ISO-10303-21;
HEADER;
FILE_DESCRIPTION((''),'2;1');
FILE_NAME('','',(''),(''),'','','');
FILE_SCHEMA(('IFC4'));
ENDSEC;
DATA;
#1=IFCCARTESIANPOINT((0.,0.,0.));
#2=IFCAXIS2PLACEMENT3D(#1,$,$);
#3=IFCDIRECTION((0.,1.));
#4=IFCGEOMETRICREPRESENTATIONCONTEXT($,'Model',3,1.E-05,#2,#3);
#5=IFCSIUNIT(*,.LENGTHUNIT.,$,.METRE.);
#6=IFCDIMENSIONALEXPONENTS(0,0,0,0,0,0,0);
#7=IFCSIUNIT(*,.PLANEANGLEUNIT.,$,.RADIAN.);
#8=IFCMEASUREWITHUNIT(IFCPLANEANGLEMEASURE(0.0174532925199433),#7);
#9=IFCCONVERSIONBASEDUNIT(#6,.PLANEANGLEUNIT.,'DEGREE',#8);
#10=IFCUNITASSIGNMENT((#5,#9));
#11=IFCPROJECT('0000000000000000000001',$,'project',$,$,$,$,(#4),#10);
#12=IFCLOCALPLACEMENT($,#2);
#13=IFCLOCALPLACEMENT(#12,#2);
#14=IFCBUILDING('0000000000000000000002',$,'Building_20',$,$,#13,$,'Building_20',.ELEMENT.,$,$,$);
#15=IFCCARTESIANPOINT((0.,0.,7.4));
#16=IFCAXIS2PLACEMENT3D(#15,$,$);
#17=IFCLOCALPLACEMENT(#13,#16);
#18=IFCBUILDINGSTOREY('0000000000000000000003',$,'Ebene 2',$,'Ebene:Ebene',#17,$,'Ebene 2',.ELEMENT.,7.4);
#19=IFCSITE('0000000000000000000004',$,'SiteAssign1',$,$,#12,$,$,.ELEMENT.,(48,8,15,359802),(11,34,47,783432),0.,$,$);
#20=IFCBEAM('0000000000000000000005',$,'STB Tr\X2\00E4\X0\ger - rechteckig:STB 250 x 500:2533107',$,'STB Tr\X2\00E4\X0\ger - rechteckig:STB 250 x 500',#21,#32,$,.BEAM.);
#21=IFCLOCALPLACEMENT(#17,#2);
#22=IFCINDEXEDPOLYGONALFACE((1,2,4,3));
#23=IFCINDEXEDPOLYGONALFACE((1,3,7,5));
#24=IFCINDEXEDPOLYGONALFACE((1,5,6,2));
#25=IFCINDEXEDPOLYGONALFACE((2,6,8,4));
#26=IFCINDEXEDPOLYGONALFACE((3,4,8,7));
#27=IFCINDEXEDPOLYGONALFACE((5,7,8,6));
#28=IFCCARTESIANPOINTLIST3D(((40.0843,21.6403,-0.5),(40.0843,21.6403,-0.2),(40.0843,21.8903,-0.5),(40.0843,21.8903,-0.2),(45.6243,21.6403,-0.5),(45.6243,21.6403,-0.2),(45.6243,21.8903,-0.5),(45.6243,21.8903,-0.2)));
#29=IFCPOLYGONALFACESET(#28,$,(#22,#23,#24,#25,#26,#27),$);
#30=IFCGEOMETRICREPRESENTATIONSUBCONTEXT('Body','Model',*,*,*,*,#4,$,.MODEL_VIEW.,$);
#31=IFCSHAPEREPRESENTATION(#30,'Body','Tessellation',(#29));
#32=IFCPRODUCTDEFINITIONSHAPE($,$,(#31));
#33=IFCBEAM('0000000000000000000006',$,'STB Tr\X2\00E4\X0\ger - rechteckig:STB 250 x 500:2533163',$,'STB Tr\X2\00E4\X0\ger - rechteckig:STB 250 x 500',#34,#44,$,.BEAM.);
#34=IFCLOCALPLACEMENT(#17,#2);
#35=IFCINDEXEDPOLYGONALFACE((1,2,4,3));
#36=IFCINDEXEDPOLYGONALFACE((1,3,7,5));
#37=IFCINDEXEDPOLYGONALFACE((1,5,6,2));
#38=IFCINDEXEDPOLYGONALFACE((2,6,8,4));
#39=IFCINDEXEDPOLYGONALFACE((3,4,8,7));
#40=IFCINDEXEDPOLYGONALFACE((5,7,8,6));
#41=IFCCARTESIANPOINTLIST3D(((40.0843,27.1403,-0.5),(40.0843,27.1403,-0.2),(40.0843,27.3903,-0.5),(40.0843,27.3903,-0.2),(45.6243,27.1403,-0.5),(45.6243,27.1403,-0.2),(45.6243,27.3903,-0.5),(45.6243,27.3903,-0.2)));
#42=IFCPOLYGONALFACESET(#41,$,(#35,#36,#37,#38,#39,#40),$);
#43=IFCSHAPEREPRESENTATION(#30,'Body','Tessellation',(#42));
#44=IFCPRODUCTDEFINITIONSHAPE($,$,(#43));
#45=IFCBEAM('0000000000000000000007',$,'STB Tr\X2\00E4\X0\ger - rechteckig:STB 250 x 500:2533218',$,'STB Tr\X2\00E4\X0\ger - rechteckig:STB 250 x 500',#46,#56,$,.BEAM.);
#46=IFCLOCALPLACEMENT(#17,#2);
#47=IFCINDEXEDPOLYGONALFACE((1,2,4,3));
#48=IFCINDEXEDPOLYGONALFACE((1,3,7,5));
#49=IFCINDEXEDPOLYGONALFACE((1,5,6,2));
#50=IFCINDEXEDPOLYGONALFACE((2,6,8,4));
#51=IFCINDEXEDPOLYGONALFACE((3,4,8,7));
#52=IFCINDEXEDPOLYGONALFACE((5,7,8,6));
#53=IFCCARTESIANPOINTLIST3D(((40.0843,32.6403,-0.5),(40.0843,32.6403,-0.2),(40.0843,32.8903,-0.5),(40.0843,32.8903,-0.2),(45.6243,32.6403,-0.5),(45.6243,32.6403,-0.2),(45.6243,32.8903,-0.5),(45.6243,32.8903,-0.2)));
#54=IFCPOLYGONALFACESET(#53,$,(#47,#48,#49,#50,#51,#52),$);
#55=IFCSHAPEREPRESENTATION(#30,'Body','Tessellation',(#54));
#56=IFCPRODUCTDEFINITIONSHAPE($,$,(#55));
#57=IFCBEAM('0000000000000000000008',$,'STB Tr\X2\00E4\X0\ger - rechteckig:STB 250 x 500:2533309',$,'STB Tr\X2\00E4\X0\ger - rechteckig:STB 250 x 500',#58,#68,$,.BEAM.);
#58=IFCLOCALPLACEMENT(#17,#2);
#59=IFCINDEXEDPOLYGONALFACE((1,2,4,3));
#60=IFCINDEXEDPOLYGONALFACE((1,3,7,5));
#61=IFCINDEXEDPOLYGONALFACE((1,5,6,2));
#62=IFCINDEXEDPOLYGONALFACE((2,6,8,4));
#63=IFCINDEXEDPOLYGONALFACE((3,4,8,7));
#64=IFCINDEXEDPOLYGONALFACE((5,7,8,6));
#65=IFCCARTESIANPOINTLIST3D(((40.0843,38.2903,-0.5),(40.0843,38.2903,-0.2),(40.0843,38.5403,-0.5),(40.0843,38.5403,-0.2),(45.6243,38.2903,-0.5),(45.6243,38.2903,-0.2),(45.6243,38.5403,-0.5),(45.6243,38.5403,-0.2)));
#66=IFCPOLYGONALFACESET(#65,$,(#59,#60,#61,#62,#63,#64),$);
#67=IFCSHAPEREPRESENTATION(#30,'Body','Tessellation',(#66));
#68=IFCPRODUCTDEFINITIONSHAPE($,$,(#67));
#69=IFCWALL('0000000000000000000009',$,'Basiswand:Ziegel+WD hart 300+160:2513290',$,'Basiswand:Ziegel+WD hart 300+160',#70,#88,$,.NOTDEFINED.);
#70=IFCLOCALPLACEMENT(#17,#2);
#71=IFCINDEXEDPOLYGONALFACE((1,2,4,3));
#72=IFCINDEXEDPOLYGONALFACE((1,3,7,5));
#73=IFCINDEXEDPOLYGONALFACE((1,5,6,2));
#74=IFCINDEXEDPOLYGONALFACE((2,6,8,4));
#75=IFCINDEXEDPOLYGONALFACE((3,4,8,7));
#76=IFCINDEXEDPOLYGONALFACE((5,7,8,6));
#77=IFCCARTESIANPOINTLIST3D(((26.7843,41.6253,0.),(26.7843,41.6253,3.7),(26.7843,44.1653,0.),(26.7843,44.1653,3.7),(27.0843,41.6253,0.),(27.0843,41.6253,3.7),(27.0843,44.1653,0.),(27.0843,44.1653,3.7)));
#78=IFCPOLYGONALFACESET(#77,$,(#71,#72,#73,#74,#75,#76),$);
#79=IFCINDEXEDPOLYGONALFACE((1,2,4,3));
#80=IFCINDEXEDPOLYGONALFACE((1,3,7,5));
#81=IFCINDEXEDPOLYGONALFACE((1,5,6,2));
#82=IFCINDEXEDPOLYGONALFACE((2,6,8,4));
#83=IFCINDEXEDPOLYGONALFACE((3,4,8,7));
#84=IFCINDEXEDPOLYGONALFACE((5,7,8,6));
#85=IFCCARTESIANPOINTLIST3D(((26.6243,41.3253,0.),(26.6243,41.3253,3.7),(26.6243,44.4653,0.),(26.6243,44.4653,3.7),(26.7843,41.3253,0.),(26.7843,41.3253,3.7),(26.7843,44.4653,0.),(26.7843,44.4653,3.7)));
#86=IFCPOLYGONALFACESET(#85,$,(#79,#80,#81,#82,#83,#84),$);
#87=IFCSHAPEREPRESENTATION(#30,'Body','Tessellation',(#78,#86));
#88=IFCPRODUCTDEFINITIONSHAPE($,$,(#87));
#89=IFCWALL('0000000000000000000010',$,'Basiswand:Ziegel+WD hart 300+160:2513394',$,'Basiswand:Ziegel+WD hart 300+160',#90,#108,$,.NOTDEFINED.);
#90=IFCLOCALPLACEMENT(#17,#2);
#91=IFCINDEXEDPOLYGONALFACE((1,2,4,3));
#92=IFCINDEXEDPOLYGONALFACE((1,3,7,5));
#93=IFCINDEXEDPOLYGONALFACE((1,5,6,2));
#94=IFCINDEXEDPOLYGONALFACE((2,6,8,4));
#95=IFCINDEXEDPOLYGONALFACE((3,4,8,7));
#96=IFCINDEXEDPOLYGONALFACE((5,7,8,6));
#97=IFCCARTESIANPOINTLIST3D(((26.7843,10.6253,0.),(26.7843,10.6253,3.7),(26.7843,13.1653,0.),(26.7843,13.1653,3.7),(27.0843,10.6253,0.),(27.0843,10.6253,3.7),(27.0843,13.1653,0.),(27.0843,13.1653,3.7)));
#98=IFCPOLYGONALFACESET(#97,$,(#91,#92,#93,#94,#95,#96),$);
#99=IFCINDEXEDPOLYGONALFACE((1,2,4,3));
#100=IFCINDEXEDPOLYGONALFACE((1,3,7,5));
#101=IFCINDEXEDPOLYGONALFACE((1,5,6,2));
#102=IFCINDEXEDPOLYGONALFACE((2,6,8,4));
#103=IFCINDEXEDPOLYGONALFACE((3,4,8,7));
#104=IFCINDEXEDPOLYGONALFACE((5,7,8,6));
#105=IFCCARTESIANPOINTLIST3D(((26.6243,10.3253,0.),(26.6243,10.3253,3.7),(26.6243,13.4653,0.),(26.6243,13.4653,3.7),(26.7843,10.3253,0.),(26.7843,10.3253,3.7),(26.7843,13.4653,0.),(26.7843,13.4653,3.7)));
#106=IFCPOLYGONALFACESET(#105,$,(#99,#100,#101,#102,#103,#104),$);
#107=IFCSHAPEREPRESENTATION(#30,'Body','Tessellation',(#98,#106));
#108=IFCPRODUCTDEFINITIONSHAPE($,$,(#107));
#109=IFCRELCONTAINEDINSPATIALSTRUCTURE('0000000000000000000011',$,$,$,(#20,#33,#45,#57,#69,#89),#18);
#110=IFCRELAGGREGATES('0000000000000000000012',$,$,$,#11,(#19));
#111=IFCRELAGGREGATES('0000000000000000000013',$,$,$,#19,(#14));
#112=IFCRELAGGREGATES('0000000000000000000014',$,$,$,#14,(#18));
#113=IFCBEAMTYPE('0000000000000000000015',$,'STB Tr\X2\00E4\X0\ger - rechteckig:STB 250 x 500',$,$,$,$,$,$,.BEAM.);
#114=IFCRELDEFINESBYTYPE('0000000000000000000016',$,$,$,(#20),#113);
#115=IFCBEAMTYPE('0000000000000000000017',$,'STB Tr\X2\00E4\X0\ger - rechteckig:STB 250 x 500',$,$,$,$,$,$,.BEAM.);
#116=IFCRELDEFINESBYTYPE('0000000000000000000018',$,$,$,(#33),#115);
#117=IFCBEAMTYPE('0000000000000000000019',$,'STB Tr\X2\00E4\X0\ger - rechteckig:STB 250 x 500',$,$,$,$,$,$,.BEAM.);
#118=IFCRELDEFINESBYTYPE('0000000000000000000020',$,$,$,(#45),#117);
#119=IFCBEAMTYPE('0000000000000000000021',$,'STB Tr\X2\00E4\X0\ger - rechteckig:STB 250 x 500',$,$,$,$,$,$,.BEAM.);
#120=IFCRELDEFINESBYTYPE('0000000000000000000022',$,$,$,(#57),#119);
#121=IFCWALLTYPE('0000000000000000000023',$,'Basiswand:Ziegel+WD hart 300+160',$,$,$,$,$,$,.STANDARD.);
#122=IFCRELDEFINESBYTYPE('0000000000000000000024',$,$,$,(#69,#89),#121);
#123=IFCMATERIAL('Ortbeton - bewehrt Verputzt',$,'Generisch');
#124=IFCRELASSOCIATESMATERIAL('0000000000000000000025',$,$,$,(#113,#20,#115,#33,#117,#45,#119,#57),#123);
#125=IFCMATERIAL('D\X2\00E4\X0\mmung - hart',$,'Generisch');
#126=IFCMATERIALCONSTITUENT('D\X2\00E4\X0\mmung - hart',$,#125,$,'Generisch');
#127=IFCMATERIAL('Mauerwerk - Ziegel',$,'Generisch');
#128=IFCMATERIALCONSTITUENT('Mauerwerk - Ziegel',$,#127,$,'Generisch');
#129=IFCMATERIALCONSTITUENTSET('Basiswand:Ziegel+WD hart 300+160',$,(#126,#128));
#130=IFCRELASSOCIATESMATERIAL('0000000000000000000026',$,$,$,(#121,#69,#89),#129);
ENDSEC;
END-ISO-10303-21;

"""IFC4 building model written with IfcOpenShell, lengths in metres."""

from ifc_helpers import new_model, entity, si_unit, converted_unit, direction, frame, origin, place, context, subcontext, project, spatial, indexed_curve, outline, extrude, source, transform, mapped, material, constituent, constituent_set, type_object, type_shapes, element, save


model = new_model("IFC4")

# Units and contexts
model_context = context("Model", 3, precision=1e-05, world=origin(), true_north=direction((0.0, 1.0)))
body_context = subcontext(model_context, "Body", "Model", "MODEL_VIEW")
ifc_project = project(units=[si_unit("LENGTHUNIT", "METRE"), converted_unit("PLANEANGLEUNIT", "DEGREE", entity("IfcPlaneAngleMeasure", 0.0174532925199433), si_unit("PLANEANGLEUNIT", "RADIAN"), dimensions=[0, 0, 0, 0, 0, 0, 0])], contexts=[model_context])

# Site, building, storey
site_placement = place(None, origin())
site = spatial("IfcSite", under=ifc_project, at=site_placement, Name="SiteAssign1", CompositionType="ELEMENT", RefLatitude=(48, 8, 15, 359802), RefLongitude=(11, 34, 47, 783432), RefElevation=0.0)
building_placement = place(site_placement, origin())
building = spatial("IfcBuilding", under=site, at=building_placement, Name="Building_20", LongName="Building_20", CompositionType="ELEMENT")
storey_placement = place(building_placement, frame((0.0, 0.0, 7.4)))
storey = spatial("IfcBuildingStorey", under=building, at=storey_placement, Name="Ebene 2", ObjectType="Ebene:Ebene", LongName="Ebene 2", CompositionType="ELEMENT", Elevation=7.4)

# Beams
ifc_material_1 = material(Name="Ortbeton - bewehrt Verputzt", Category="Generisch")
beam_type_1 = type_object("IfcBeamType", Name="STB Träger - rechteckig:STB 250 x 500", PredefinedType="BEAM", material=ifc_material_1)
shared_shape_1 = source(origin(), body_context, "Body", "SweptSolid", [
    extrude(outline(indexed_curve([(-0.15, -0.125), (0.15, -0.125), (0.15, 0.125), (-0.15, 0.125), (-0.15, -0.125)], self_intersect=False)), frame((40.0843, 21.7653, 7.05), z_axis=(1.0, 0.0, 0.0), x_axis=(0.0, 0.0, -1.0)), (0.0, 0.0, 1.0), 5.54),
])
type_shapes(beam_type_1, [shared_shape_1])
beam_1_placement = place(storey_placement, frame((0.0, 0.0, -7.4)))
element("IfcBeam", 1, at=beam_1_placement, inside=storey, type_object=beam_type_1, material=ifc_material_1, Name="STB Träger - rechteckig:STB 250 x 500:2533107", ObjectType="STB Träger - rechteckig:STB 250 x 500", PredefinedType="BEAM", context=body_context, shape_type="MappedRepresentation", body=[
    mapped(shared_shape_1, transform((0.0, 0.0, 0.0), scale=1.0)),
])
beam_type_2 = type_object("IfcBeamType", Name="STB Träger - rechteckig:STB 250 x 500", PredefinedType="BEAM", material=ifc_material_1)
shared_shape_2 = source(origin(), body_context, "Body", "SweptSolid", [
    extrude(outline(indexed_curve([(-0.15, -0.125), (0.15, -0.125), (0.15, 0.125), (-0.15, 0.125), (-0.15, -0.125)], self_intersect=False)), frame((40.0843, 27.2653, 7.05), z_axis=(1.0, 0.0, 0.0), x_axis=(0.0, 0.0, -1.0)), (0.0, 0.0, 1.0), 5.54),
])
type_shapes(beam_type_2, [shared_shape_2])
beam_2_placement = place(storey_placement, frame((0.0, 0.0, -7.4)))
element("IfcBeam", 2, at=beam_2_placement, inside=storey, type_object=beam_type_2, material=ifc_material_1, Name="STB Träger - rechteckig:STB 250 x 500:2533163", ObjectType="STB Träger - rechteckig:STB 250 x 500", PredefinedType="BEAM", context=body_context, shape_type="MappedRepresentation", body=[
    mapped(shared_shape_2, transform((0.0, 0.0, 0.0), scale=1.0)),
])
beam_type_3 = type_object("IfcBeamType", Name="STB Träger - rechteckig:STB 250 x 500", PredefinedType="BEAM", material=ifc_material_1)
shared_shape_3 = source(origin(), body_context, "Body", "SweptSolid", [
    extrude(outline(indexed_curve([(-0.15, -0.125), (0.15, -0.125), (0.15, 0.125), (-0.15, 0.125), (-0.15, -0.125)], self_intersect=False)), frame((40.0843, 32.7653, 7.05), z_axis=(1.0, 0.0, 0.0), x_axis=(0.0, 0.0, -1.0)), (0.0, 0.0, 1.0), 5.54),
])
type_shapes(beam_type_3, [shared_shape_3])
beam_3_placement = place(storey_placement, frame((0.0, 0.0, -7.4)))
element("IfcBeam", 3, at=beam_3_placement, inside=storey, type_object=beam_type_3, material=ifc_material_1, Name="STB Träger - rechteckig:STB 250 x 500:2533218", ObjectType="STB Träger - rechteckig:STB 250 x 500", PredefinedType="BEAM", context=body_context, shape_type="MappedRepresentation", body=[
    mapped(shared_shape_3, transform((0.0, 0.0, 0.0), scale=1.0)),
])
beam_type_4 = type_object("IfcBeamType", Name="STB Träger - rechteckig:STB 250 x 500", PredefinedType="BEAM", material=ifc_material_1)
shared_shape_4 = source(origin(), body_context, "Body", "SweptSolid", [
    extrude(outline(indexed_curve([(-0.15, -0.125), (0.15, -0.125), (0.15, 0.125), (-0.15, 0.125), (-0.15, -0.125)], self_intersect=False)), frame((40.0843, 38.4153, 7.05), z_axis=(1.0, 0.0, 0.0), x_axis=(0.0, 0.0, -1.0)), (0.0, 0.0, 1.0), 5.54),
])
type_shapes(beam_type_4, [shared_shape_4])
beam_4_placement = place(storey_placement, frame((0.0, 0.0, -7.4)))
element("IfcBeam", 4, at=beam_4_placement, inside=storey, type_object=beam_type_4, material=ifc_material_1, Name="STB Träger - rechteckig:STB 250 x 500:2533309", ObjectType="STB Träger - rechteckig:STB 250 x 500", PredefinedType="BEAM", context=body_context, shape_type="MappedRepresentation", body=[
    mapped(shared_shape_4, transform((0.0, 0.0, 0.0), scale=1.0)),
])

# Walls
ifc_material_2 = material(Name="Dämmung - hart", Category="Generisch")
ifc_constituent_1 = constituent(ifc_material_2, Name="Dämmung - hart", Category="Generisch")
ifc_material_3 = material(Name="Mauerwerk - Ziegel", Category="Generisch")
ifc_constituent_2 = constituent(ifc_material_3, Name="Mauerwerk - Ziegel", Category="Generisch")
ifc_constituent_set = constituent_set(constituents=[ifc_constituent_1, ifc_constituent_2], Name="Basiswand:Ziegel+WD hart 300+160")
wall_type = type_object("IfcWallType", Name="Basiswand:Ziegel+WD hart 300+160", PredefinedType="STANDARD", material=ifc_constituent_set)
wall_1_placement = place(storey_placement, frame((26.8543, 41.6253, 0.0), z_axis=(0.0, 0.0, 1.0), x_axis=(0.0, 1.0, 0.0)))
element("IfcWall", 5, at=wall_1_placement, inside=storey, type_object=wall_type, material=ifc_constituent_set, Name="Basiswand:Ziegel+WD hart 300+160:2513290", ObjectType="Basiswand:Ziegel+WD hart 300+160", PredefinedType="NOTDEFINED", context=body_context, shape_type="SweptSolid", body=[
    extrude(outline(indexed_curve([(-0.15, -1.27), (0.15, -1.27), (0.15, 1.27), (-0.15, 1.27), (-0.15, -1.27)], self_intersect=False)), frame((1.27, -0.08, 0.0), z_axis=(0.0, 0.0, 1.0), x_axis=(0.0, 1.0, 0.0)), (0.0, 0.0, 1.0), 3.7),
    extrude(outline(indexed_curve([(-0.08, -1.57), (0.08, -1.57), (0.08, 1.57), (-0.08, 1.57), (-0.08, -1.57)], self_intersect=False)), frame((1.27, 0.15, 0.0), z_axis=(0.0, 0.0, 1.0), x_axis=(0.0, -1.0, 0.0)), (0.0, 0.0, 1.0), 3.7),
])
wall_2_placement = place(storey_placement, frame((26.8543, 10.6253, 0.0), z_axis=(0.0, 0.0, 1.0), x_axis=(0.0, 1.0, 0.0)))
element("IfcWall", 6, at=wall_2_placement, inside=storey, type_object=wall_type, material=ifc_constituent_set, Name="Basiswand:Ziegel+WD hart 300+160:2513394", ObjectType="Basiswand:Ziegel+WD hart 300+160", PredefinedType="NOTDEFINED", context=body_context, shape_type="SweptSolid", body=[
    extrude(outline(indexed_curve([(-0.15, -1.27), (0.15, -1.27), (0.15, 1.27), (-0.15, 1.27), (-0.15, -1.27)], self_intersect=False)), frame((1.27, -0.08, 0.0), z_axis=(0.0, 0.0, 1.0), x_axis=(0.0, 1.0, 0.0)), (0.0, 0.0, 1.0), 3.7),
    extrude(outline(indexed_curve([(-0.08, -1.57), (0.08, -1.57), (0.08, 1.57), (-0.08, 1.57), (-0.08, -1.57)], self_intersect=False)), frame((1.27, 0.15, 0.0), z_axis=(0.0, 0.0, 1.0), x_axis=(0.0, -1.0, 0.0)), (0.0, 0.0, 1.0), 3.7),
])

save(model, "model.ifc")
